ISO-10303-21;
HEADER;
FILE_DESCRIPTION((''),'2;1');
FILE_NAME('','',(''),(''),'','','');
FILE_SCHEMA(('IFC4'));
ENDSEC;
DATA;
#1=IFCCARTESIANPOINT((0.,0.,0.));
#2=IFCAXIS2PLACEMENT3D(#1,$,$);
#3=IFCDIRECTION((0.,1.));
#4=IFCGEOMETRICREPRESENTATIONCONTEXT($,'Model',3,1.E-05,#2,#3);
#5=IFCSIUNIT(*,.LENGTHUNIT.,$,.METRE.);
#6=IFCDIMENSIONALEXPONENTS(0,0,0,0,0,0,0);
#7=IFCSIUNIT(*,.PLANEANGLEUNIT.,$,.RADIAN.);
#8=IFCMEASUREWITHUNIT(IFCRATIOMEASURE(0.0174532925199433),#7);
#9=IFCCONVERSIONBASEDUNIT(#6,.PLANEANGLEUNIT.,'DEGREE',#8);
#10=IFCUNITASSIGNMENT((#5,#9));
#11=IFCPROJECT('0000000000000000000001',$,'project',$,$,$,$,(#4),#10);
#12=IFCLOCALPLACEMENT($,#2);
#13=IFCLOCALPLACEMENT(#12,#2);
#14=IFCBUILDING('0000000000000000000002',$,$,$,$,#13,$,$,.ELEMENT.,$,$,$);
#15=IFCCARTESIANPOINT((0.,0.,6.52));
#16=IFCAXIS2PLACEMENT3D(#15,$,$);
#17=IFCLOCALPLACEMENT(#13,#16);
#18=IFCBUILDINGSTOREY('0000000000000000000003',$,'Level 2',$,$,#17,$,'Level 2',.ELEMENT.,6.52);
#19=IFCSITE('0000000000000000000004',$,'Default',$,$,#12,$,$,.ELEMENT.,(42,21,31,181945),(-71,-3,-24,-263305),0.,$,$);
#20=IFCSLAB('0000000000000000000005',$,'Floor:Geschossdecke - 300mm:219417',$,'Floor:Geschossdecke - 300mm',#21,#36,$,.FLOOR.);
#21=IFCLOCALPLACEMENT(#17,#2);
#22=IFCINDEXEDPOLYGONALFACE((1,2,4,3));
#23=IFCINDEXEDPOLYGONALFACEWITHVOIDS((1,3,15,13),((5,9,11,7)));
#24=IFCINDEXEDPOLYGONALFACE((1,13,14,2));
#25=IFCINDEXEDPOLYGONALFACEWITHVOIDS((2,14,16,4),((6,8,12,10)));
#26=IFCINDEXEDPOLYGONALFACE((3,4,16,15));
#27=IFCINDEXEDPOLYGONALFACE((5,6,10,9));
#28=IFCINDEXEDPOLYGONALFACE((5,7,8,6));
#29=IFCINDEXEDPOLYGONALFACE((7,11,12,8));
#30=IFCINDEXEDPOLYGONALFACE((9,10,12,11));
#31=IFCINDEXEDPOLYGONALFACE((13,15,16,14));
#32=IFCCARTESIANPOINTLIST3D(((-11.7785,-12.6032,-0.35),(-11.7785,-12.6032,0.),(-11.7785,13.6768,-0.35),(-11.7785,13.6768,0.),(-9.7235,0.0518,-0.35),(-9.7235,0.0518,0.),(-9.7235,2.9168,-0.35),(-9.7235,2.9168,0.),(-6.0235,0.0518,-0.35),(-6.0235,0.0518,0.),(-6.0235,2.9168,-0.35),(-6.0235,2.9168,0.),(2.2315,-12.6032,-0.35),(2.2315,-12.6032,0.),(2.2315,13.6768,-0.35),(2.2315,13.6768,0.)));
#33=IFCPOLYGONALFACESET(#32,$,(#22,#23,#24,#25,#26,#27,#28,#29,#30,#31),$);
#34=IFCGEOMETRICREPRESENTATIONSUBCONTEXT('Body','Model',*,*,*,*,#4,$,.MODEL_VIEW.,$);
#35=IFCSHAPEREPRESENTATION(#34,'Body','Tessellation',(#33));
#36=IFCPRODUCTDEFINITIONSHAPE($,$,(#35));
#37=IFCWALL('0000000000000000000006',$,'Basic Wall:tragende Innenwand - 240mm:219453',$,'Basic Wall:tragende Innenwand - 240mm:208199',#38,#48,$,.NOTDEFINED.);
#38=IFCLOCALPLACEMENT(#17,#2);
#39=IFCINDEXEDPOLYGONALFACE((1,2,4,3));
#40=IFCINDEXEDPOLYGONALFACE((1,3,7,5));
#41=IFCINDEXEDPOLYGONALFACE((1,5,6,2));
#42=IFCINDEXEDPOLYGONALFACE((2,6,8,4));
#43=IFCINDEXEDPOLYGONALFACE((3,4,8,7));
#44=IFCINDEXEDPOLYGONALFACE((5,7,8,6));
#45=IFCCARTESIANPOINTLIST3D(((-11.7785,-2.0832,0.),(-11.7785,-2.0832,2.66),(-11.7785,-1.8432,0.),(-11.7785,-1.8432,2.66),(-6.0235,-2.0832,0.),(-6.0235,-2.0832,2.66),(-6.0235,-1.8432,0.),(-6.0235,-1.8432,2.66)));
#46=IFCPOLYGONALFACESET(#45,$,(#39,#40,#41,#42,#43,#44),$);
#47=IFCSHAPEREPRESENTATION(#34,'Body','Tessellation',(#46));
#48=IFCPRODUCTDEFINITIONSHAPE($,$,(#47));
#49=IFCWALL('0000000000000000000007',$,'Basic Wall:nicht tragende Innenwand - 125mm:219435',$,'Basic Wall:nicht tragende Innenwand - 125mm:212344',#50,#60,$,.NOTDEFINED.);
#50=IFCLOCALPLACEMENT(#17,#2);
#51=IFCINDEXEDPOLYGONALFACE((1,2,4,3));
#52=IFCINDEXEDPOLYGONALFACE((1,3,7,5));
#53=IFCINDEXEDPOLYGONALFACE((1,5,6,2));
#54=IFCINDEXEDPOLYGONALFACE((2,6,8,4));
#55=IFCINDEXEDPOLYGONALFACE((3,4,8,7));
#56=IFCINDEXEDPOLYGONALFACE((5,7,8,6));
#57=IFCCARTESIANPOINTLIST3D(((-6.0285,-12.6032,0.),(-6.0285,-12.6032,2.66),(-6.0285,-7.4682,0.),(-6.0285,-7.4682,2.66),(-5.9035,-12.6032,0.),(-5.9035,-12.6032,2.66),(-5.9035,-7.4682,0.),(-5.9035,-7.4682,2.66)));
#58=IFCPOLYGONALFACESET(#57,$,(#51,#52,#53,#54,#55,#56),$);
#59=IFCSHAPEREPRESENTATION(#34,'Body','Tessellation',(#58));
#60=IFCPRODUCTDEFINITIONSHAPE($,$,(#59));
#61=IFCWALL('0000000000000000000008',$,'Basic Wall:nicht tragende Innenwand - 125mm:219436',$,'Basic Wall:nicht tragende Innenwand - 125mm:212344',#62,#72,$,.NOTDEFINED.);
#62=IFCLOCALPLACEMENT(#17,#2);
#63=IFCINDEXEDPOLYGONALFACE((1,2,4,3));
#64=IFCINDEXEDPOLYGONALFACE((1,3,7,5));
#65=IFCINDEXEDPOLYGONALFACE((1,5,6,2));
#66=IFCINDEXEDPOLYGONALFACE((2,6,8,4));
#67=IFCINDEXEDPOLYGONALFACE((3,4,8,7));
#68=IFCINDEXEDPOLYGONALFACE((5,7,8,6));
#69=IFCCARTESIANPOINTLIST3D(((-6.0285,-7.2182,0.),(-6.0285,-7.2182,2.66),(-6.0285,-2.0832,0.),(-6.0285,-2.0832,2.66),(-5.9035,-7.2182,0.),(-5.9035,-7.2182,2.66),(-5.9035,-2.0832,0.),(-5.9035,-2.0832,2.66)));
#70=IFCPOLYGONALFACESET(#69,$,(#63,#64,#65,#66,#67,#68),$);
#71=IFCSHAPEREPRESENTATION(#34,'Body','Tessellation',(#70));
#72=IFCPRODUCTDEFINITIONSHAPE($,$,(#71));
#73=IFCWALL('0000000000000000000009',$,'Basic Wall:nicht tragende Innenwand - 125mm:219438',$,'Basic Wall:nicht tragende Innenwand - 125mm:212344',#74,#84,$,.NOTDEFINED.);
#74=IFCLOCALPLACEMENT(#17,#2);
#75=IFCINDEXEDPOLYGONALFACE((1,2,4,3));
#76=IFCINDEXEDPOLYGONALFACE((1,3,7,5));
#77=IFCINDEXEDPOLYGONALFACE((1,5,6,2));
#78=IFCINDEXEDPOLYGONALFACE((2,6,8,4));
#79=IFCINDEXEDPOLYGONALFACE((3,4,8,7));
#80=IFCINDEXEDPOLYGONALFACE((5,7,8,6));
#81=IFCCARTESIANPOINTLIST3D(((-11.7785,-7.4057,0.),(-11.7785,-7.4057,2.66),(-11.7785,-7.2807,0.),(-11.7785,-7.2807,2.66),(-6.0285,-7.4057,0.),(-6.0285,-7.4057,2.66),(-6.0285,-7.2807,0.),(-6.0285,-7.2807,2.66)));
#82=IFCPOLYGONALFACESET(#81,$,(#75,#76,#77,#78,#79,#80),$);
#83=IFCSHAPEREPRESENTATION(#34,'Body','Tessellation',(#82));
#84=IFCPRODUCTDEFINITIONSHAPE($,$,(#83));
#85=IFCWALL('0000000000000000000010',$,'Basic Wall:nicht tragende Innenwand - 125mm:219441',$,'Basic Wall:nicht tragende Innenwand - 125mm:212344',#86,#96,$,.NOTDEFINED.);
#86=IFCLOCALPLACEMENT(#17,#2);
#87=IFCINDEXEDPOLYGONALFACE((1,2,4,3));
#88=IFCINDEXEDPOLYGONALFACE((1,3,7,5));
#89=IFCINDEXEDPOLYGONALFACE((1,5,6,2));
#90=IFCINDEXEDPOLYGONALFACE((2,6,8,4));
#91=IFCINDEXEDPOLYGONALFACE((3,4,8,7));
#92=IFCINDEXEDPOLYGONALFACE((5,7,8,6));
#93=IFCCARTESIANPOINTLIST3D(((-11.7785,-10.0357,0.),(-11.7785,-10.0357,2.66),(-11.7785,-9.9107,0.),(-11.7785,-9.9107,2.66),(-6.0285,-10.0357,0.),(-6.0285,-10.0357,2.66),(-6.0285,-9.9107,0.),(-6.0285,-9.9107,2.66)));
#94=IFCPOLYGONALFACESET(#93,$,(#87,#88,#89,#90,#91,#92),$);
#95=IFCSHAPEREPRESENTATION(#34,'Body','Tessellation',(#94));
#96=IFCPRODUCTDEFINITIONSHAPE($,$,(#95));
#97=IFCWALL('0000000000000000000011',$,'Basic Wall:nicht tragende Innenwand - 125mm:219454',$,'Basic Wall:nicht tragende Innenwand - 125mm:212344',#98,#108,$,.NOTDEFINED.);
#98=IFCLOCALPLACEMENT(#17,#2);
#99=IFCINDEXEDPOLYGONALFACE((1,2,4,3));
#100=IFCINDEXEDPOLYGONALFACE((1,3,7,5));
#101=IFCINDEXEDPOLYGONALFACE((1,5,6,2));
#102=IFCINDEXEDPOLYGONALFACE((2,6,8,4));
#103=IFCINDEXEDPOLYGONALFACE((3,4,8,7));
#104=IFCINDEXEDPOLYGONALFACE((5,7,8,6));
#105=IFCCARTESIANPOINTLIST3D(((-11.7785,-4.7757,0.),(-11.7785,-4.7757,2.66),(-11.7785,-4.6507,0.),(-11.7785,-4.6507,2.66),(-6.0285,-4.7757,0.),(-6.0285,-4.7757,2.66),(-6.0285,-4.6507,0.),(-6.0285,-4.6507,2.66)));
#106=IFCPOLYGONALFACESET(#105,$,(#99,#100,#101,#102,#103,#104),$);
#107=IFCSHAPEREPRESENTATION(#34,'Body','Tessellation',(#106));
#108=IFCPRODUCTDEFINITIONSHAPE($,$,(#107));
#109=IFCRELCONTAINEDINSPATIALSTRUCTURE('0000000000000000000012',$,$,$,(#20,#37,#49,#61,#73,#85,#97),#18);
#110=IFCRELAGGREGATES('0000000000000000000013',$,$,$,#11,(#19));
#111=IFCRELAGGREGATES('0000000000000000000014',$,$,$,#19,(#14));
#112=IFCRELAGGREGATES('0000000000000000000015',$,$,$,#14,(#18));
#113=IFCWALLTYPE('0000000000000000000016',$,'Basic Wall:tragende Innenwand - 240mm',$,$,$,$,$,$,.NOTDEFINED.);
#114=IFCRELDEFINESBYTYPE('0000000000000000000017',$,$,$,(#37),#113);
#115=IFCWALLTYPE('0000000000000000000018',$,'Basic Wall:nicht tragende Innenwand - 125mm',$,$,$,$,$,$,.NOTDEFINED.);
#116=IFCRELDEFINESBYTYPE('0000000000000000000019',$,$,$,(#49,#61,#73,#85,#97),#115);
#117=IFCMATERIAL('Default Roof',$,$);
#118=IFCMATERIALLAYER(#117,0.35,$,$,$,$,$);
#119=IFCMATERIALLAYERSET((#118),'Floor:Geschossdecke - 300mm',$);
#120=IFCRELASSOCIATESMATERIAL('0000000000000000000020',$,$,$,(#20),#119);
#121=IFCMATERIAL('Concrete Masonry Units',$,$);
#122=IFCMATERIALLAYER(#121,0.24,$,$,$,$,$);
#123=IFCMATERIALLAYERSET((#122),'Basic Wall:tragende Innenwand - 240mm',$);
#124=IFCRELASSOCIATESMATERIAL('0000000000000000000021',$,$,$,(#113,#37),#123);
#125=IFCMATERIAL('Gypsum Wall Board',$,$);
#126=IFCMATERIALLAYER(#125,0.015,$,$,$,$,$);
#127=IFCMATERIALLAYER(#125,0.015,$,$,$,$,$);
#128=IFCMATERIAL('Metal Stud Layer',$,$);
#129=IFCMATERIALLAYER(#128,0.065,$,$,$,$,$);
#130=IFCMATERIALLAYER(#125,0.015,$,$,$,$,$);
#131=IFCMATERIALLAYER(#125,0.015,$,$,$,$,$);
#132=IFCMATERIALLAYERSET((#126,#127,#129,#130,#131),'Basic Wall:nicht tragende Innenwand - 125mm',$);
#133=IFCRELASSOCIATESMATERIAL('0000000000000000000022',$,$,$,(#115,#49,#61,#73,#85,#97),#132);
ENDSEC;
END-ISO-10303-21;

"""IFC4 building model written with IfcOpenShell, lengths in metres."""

from ifc_helpers import new_model, entity, si_unit, converted_unit, direction, frame, frame_2d, origin, origin_2d_with_axis, place, context, subcontext, project, spatial, rectangle, extrude, material, layer, layer_set, layer_usage, type_object, element, save


model = new_model("IFC4")

# Units and contexts
model_context = context("Model", 3, precision=1e-05, world=origin(), true_north=direction((0.0, 1.0)))
body_context = subcontext(model_context, "Body", "Model", "MODEL_VIEW")
ifc_project = project(units=[si_unit("LENGTHUNIT", "METRE"), converted_unit("PLANEANGLEUNIT", "DEGREE", entity("IfcRatioMeasure", 0.0174532925199433), si_unit("PLANEANGLEUNIT", "RADIAN"), dimensions=[0, 0, 0, 0, 0, 0, 0])], contexts=[model_context])

# Site, building, storey
site_placement = place(None, origin())
site = spatial("IfcSite", under=ifc_project, at=site_placement, Name="Default", CompositionType="ELEMENT", RefLatitude=(42, 21, 31, 181945), RefLongitude=(-71, -3, -24, -263305), RefElevation=0.0)
building_placement = place(site_placement, origin())
building = spatial("IfcBuilding", under=site, at=building_placement, CompositionType="ELEMENT")
storey_placement = place(building_placement, frame((0.0, 0.0, 6.52)))
storey = spatial("IfcBuildingStorey", under=building, at=storey_placement, Name="Level 2", LongName="Level 2", CompositionType="ELEMENT", Elevation=6.52)

# Slab, opening
ifc_material_1 = material(Name="Default Roof")
ifc_layer_1 = layer(ifc_material_1, 0.35)
ifc_layer_set_1 = layer_set([ifc_layer_1], Name="Floor:Geschossdecke - 300mm")
ifc_layer_usage_1 = layer_usage(ifc_layer_set_1, "AXIS3", "POSITIVE", 0.0)
slab_placement = place(storey_placement, frame((-11.7785, -12.6032, -0.35)))
slab = element("IfcSlab", 1, at=slab_placement, inside=storey, material=ifc_layer_usage_1, Name="Floor:Geschossdecke - 300mm:219417", ObjectType="Floor:Geschossdecke - 300mm", PredefinedType="FLOOR", context=body_context, shape_type="SweptSolid", body=[
    extrude(rectangle(XDim=26.28, YDim=14.01, at=frame_2d((0.0, 0.0), x_axis=(0.0, -1.0))), frame((7.005, 13.14, 0.35), z_axis=(0.0, 0.0, -1.0), x_axis=(-1.0, 0.0, 0.0)), (0.0, 0.0, 1.0), 0.35),
])
opening_1_placement = place(slab_placement, frame((3.905, 14.0875, 0.35)))
element("IfcOpeningElement", 2, at=opening_1_placement, cuts=slab, ObjectType="Opening", context=body_context, shape_type="SweptSolid", body=[
    extrude(rectangle(XDim=3.7, YDim=2.865, at=origin_2d_with_axis()), frame((0.0, 0.0, 0.0), z_axis=(0.0, 0.0, -1.0), x_axis=(1.0, 0.0, 0.0)), (0.0, 0.0, 1.0), 0.35),
])

# Walls
ifc_material_2 = material(Name="Concrete Masonry Units")
ifc_layer_2 = layer(ifc_material_2, 0.24)
ifc_layer_set_2 = layer_set([ifc_layer_2], Name="Basic Wall:tragende Innenwand - 240mm")
ifc_layer_usage_2 = layer_usage(ifc_layer_set_2, "AXIS2", "POSITIVE", -0.12)
wall_type_1 = type_object("IfcWallType", Name="Basic Wall:tragende Innenwand - 240mm", PredefinedType="NOTDEFINED", material=ifc_layer_set_2)
wall_1_placement = place(storey_placement, frame((-11.7785, -1.9632, 0.0)))
element("IfcWall", 3, at=wall_1_placement, inside=storey, type_object=wall_type_1, material=ifc_layer_usage_2, Name="Basic Wall:tragende Innenwand - 240mm:219453", ObjectType="Basic Wall:tragende Innenwand - 240mm:208199", PredefinedType="NOTDEFINED", context=body_context, shape_type="SweptSolid", body=[
    extrude(rectangle(XDim=5.755, YDim=0.24, at=frame_2d((2.8775, 0.0), x_axis=(-1.0, 0.0))), origin(), (0.0, 0.0, 1.0), 2.66),
])
ifc_material_3 = material(Name="Gypsum Wall Board")
ifc_layer_3 = layer(ifc_material_3, 0.015)
ifc_layer_4 = layer(ifc_material_3, 0.015)
ifc_material_4 = material(Name="Metal Stud Layer")
ifc_layer_5 = layer(ifc_material_4, 0.065)
ifc_layer_6 = layer(ifc_material_3, 0.015)
ifc_layer_7 = layer(ifc_material_3, 0.015)
ifc_layer_set_3 = layer_set([ifc_layer_3, ifc_layer_4, ifc_layer_5, ifc_layer_6, ifc_layer_7], Name="Basic Wall:nicht tragende Innenwand - 125mm")
ifc_layer_usage_3 = layer_usage(ifc_layer_set_3, "AXIS2", "NEGATIVE", 0.0625)
wall_type_2 = type_object("IfcWallType", Name="Basic Wall:nicht tragende Innenwand - 125mm", PredefinedType="NOTDEFINED", material=ifc_layer_set_3)
wall_2_placement = place(storey_placement, frame((-5.966, -7.4682, 0.0), z_axis=(0.0, 0.0, 1.0), x_axis=(0.0, -1.0, 0.0)))
element("IfcWall", 4, at=wall_2_placement, inside=storey, type_object=wall_type_2, material=ifc_layer_usage_3, Name="Basic Wall:nicht tragende Innenwand - 125mm:219435", ObjectType="Basic Wall:nicht tragende Innenwand - 125mm:212344", PredefinedType="NOTDEFINED", context=body_context, shape_type="SweptSolid", body=[
    extrude(rectangle(XDim=5.135, YDim=0.125, at=frame_2d((2.5675, 0.0), x_axis=(-1.0, 0.0))), origin(), (0.0, 0.0, 1.0), 2.66),
])
ifc_layer_usage_4 = layer_usage(ifc_layer_set_3, "AXIS2", "NEGATIVE", 0.0625)
wall_3_placement = place(storey_placement, frame((-5.966, -2.0832, 0.0), z_axis=(0.0, 0.0, 1.0), x_axis=(0.0, -1.0, 0.0)))
element("IfcWall", 5, at=wall_3_placement, inside=storey, type_object=wall_type_2, material=ifc_layer_usage_4, Name="Basic Wall:nicht tragende Innenwand - 125mm:219436", ObjectType="Basic Wall:nicht tragende Innenwand - 125mm:212344", PredefinedType="NOTDEFINED", context=body_context, shape_type="SweptSolid", body=[
    extrude(rectangle(XDim=5.135, YDim=0.125, at=frame_2d((2.5675, 0.0), x_axis=(-1.0, 0.0))), origin(), (0.0, 0.0, 1.0), 2.66),
])
ifc_layer_usage_5 = layer_usage(ifc_layer_set_3, "AXIS2", "NEGATIVE", 0.0625)
wall_4_placement = place(storey_placement, frame((-11.7785, -7.3432, 0.0)))
element("IfcWall", 6, at=wall_4_placement, inside=storey, type_object=wall_type_2, material=ifc_layer_usage_5, Name="Basic Wall:nicht tragende Innenwand - 125mm:219438", ObjectType="Basic Wall:nicht tragende Innenwand - 125mm:212344", PredefinedType="NOTDEFINED", context=body_context, shape_type="SweptSolid", body=[
    extrude(rectangle(XDim=5.75, YDim=0.125, at=frame_2d((2.875, 0.0), x_axis=(-1.0, 0.0))), origin(), (0.0, 0.0, 1.0), 2.66),
])
ifc_layer_usage_6 = layer_usage(ifc_layer_set_3, "AXIS2", "NEGATIVE", 0.0625)
wall_5_placement = place(storey_placement, frame((-11.7785, -9.9732, 0.0)))
element("IfcWall", 7, at=wall_5_placement, inside=storey, type_object=wall_type_2, material=ifc_layer_usage_6, Name="Basic Wall:nicht tragende Innenwand - 125mm:219441", ObjectType="Basic Wall:nicht tragende Innenwand - 125mm:212344", PredefinedType="NOTDEFINED", context=body_context, shape_type="SweptSolid", body=[
    extrude(rectangle(XDim=5.75, YDim=0.125, at=frame_2d((2.875, 0.0), x_axis=(-1.0, 0.0))), origin(), (0.0, 0.0, 1.0), 2.66),
])
ifc_layer_usage_7 = layer_usage(ifc_layer_set_3, "AXIS2", "POSITIVE", -0.0625)
wall_6_placement = place(storey_placement, frame((-11.7785, -4.7132, 0.0)))
element("IfcWall", 8, at=wall_6_placement, inside=storey, type_object=wall_type_2, material=ifc_layer_usage_7, Name="Basic Wall:nicht tragende Innenwand - 125mm:219454", ObjectType="Basic Wall:nicht tragende Innenwand - 125mm:212344", PredefinedType="NOTDEFINED", context=body_context, shape_type="SweptSolid", body=[
    extrude(rectangle(XDim=5.75, YDim=0.125, at=frame_2d((2.875, 0.0), x_axis=(-1.0, 0.0))), origin(), (0.0, 0.0, 1.0), 2.66),
])

save(model, "model.ifc")
